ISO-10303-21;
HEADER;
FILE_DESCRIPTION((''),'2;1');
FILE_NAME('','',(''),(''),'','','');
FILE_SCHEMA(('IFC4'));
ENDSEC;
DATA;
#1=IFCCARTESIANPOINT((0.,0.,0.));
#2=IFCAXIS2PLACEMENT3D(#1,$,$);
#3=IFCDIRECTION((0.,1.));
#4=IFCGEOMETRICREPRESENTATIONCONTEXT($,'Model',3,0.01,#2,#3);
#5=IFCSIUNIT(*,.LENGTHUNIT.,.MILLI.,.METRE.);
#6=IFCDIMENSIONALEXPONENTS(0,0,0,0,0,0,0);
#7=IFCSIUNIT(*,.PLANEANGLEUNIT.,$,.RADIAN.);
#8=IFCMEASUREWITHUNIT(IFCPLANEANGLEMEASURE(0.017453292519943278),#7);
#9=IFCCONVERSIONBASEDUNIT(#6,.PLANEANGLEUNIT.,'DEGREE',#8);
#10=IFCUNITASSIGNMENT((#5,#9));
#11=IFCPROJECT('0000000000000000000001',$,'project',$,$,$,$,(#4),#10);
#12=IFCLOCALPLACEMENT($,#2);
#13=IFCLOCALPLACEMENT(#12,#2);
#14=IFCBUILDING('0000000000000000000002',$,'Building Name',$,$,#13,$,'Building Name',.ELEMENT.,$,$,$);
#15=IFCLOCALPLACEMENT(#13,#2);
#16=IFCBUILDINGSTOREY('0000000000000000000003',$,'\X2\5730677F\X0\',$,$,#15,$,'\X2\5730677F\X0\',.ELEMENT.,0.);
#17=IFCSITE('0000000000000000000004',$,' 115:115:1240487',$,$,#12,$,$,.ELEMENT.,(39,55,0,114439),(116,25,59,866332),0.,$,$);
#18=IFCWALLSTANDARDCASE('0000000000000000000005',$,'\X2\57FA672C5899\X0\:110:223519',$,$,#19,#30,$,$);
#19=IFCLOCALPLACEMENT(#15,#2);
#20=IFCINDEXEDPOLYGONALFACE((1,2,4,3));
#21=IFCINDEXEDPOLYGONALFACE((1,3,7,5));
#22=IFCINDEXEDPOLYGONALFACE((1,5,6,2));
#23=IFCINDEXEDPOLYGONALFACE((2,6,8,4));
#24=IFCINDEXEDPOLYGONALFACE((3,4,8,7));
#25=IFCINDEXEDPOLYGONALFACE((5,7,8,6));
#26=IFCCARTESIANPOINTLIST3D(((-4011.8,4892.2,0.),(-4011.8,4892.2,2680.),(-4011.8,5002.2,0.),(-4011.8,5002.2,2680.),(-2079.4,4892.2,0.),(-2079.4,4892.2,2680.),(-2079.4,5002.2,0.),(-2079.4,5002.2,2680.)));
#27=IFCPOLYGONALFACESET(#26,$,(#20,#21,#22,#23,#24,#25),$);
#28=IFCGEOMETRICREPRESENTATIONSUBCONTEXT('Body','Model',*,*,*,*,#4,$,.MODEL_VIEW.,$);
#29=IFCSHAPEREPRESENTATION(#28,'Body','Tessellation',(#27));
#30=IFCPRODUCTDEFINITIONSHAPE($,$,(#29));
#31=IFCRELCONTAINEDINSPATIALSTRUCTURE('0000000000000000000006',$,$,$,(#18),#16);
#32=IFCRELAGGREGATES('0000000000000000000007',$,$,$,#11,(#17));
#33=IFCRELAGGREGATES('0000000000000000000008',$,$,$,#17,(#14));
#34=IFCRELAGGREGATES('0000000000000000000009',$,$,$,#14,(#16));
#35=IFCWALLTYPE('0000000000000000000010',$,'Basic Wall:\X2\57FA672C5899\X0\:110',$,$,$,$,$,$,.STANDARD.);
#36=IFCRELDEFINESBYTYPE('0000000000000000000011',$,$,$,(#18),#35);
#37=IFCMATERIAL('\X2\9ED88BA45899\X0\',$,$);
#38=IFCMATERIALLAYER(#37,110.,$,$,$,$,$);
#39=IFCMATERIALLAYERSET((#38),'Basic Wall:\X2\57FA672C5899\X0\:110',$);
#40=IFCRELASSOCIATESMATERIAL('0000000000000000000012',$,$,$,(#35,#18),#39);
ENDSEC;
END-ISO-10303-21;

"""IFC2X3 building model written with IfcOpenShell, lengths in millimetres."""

from ifc_helpers import new_model, entity, si_unit, converted_unit, direction, frame, frame_2d, origin, place, context, subcontext, project, spatial, rectangle, extrude, material, layer, layer_set, layer_usage, type_object, element, save


model = new_model("IFC2X3")

# Units and contexts
model_context = context("Model", 3, precision=0.01, world=origin(), true_north=direction((0.0, 1.0)))
body_context = subcontext(model_context, "Body", "Model", "MODEL_VIEW")
ifc_project = project(units=[si_unit("LENGTHUNIT", "METRE", prefix="MILLI"), converted_unit("PLANEANGLEUNIT", "DEGREE", entity("IfcPlaneAngleMeasure", 0.017453292519943278), si_unit("PLANEANGLEUNIT", "RADIAN"), dimensions=[0, 0, 0, 0, 0, 0, 0])], contexts=[model_context])

# Site, building, storey
site_placement = place(None, origin())
site = spatial("IfcSite", under=ifc_project, at=site_placement, Name=" 115:115:1240487", CompositionType="ELEMENT", RefLatitude=(39, 55, 0, 114439), RefLongitude=(116, 25, 59, 866332), RefElevation=0.0)
building_placement = place(site_placement, origin())
building = spatial("IfcBuilding", under=site, at=building_placement, Name="Building Name", LongName="Building Name", CompositionType="ELEMENT")
storey_placement = place(building_placement, origin())
storey = spatial("IfcBuildingStorey", under=building, at=storey_placement, Name="地板", LongName="地板", CompositionType="ELEMENT", Elevation=0.0)

# Shared definitions
ifc_material_1 = material(Name="默认墙")

# Wall
ifc_layer_1 = layer(ifc_material_1, 110.0)
ifc_layer_set_1 = layer_set([ifc_layer_1], Name="Basic Wall:基本墙:110")
ifc_layer_usage_1 = layer_usage(ifc_layer_set_1, "AXIS2", "NEGATIVE", 55.0)
wall_type_1 = type_object("IfcWallType", Name="Basic Wall:基本墙:110", PredefinedType="STANDARD", material=ifc_layer_set_1)
wall_1_placement = place(storey_placement, frame((-2079.4, 4947.2, 0.0), z_axis=(0.0, 0.0, 1.0), x_axis=(-1.0, 0.0, 0.0)))
element("IfcWallStandardCase", 1, at=wall_1_placement, inside=storey, type_object=wall_type_1, material=ifc_layer_usage_1, Name="基本墙:110:223519", context=body_context, shape_type="SweptSolid", body=[
    extrude(rectangle(XDim=1932.4, YDim=110.0, at=frame_2d((966.2, 0.0), x_axis=(-1.0, 0.0))), origin(), (0.0, 0.0, 1.0), 2680.0),
])

save(model, "model.ifc")
